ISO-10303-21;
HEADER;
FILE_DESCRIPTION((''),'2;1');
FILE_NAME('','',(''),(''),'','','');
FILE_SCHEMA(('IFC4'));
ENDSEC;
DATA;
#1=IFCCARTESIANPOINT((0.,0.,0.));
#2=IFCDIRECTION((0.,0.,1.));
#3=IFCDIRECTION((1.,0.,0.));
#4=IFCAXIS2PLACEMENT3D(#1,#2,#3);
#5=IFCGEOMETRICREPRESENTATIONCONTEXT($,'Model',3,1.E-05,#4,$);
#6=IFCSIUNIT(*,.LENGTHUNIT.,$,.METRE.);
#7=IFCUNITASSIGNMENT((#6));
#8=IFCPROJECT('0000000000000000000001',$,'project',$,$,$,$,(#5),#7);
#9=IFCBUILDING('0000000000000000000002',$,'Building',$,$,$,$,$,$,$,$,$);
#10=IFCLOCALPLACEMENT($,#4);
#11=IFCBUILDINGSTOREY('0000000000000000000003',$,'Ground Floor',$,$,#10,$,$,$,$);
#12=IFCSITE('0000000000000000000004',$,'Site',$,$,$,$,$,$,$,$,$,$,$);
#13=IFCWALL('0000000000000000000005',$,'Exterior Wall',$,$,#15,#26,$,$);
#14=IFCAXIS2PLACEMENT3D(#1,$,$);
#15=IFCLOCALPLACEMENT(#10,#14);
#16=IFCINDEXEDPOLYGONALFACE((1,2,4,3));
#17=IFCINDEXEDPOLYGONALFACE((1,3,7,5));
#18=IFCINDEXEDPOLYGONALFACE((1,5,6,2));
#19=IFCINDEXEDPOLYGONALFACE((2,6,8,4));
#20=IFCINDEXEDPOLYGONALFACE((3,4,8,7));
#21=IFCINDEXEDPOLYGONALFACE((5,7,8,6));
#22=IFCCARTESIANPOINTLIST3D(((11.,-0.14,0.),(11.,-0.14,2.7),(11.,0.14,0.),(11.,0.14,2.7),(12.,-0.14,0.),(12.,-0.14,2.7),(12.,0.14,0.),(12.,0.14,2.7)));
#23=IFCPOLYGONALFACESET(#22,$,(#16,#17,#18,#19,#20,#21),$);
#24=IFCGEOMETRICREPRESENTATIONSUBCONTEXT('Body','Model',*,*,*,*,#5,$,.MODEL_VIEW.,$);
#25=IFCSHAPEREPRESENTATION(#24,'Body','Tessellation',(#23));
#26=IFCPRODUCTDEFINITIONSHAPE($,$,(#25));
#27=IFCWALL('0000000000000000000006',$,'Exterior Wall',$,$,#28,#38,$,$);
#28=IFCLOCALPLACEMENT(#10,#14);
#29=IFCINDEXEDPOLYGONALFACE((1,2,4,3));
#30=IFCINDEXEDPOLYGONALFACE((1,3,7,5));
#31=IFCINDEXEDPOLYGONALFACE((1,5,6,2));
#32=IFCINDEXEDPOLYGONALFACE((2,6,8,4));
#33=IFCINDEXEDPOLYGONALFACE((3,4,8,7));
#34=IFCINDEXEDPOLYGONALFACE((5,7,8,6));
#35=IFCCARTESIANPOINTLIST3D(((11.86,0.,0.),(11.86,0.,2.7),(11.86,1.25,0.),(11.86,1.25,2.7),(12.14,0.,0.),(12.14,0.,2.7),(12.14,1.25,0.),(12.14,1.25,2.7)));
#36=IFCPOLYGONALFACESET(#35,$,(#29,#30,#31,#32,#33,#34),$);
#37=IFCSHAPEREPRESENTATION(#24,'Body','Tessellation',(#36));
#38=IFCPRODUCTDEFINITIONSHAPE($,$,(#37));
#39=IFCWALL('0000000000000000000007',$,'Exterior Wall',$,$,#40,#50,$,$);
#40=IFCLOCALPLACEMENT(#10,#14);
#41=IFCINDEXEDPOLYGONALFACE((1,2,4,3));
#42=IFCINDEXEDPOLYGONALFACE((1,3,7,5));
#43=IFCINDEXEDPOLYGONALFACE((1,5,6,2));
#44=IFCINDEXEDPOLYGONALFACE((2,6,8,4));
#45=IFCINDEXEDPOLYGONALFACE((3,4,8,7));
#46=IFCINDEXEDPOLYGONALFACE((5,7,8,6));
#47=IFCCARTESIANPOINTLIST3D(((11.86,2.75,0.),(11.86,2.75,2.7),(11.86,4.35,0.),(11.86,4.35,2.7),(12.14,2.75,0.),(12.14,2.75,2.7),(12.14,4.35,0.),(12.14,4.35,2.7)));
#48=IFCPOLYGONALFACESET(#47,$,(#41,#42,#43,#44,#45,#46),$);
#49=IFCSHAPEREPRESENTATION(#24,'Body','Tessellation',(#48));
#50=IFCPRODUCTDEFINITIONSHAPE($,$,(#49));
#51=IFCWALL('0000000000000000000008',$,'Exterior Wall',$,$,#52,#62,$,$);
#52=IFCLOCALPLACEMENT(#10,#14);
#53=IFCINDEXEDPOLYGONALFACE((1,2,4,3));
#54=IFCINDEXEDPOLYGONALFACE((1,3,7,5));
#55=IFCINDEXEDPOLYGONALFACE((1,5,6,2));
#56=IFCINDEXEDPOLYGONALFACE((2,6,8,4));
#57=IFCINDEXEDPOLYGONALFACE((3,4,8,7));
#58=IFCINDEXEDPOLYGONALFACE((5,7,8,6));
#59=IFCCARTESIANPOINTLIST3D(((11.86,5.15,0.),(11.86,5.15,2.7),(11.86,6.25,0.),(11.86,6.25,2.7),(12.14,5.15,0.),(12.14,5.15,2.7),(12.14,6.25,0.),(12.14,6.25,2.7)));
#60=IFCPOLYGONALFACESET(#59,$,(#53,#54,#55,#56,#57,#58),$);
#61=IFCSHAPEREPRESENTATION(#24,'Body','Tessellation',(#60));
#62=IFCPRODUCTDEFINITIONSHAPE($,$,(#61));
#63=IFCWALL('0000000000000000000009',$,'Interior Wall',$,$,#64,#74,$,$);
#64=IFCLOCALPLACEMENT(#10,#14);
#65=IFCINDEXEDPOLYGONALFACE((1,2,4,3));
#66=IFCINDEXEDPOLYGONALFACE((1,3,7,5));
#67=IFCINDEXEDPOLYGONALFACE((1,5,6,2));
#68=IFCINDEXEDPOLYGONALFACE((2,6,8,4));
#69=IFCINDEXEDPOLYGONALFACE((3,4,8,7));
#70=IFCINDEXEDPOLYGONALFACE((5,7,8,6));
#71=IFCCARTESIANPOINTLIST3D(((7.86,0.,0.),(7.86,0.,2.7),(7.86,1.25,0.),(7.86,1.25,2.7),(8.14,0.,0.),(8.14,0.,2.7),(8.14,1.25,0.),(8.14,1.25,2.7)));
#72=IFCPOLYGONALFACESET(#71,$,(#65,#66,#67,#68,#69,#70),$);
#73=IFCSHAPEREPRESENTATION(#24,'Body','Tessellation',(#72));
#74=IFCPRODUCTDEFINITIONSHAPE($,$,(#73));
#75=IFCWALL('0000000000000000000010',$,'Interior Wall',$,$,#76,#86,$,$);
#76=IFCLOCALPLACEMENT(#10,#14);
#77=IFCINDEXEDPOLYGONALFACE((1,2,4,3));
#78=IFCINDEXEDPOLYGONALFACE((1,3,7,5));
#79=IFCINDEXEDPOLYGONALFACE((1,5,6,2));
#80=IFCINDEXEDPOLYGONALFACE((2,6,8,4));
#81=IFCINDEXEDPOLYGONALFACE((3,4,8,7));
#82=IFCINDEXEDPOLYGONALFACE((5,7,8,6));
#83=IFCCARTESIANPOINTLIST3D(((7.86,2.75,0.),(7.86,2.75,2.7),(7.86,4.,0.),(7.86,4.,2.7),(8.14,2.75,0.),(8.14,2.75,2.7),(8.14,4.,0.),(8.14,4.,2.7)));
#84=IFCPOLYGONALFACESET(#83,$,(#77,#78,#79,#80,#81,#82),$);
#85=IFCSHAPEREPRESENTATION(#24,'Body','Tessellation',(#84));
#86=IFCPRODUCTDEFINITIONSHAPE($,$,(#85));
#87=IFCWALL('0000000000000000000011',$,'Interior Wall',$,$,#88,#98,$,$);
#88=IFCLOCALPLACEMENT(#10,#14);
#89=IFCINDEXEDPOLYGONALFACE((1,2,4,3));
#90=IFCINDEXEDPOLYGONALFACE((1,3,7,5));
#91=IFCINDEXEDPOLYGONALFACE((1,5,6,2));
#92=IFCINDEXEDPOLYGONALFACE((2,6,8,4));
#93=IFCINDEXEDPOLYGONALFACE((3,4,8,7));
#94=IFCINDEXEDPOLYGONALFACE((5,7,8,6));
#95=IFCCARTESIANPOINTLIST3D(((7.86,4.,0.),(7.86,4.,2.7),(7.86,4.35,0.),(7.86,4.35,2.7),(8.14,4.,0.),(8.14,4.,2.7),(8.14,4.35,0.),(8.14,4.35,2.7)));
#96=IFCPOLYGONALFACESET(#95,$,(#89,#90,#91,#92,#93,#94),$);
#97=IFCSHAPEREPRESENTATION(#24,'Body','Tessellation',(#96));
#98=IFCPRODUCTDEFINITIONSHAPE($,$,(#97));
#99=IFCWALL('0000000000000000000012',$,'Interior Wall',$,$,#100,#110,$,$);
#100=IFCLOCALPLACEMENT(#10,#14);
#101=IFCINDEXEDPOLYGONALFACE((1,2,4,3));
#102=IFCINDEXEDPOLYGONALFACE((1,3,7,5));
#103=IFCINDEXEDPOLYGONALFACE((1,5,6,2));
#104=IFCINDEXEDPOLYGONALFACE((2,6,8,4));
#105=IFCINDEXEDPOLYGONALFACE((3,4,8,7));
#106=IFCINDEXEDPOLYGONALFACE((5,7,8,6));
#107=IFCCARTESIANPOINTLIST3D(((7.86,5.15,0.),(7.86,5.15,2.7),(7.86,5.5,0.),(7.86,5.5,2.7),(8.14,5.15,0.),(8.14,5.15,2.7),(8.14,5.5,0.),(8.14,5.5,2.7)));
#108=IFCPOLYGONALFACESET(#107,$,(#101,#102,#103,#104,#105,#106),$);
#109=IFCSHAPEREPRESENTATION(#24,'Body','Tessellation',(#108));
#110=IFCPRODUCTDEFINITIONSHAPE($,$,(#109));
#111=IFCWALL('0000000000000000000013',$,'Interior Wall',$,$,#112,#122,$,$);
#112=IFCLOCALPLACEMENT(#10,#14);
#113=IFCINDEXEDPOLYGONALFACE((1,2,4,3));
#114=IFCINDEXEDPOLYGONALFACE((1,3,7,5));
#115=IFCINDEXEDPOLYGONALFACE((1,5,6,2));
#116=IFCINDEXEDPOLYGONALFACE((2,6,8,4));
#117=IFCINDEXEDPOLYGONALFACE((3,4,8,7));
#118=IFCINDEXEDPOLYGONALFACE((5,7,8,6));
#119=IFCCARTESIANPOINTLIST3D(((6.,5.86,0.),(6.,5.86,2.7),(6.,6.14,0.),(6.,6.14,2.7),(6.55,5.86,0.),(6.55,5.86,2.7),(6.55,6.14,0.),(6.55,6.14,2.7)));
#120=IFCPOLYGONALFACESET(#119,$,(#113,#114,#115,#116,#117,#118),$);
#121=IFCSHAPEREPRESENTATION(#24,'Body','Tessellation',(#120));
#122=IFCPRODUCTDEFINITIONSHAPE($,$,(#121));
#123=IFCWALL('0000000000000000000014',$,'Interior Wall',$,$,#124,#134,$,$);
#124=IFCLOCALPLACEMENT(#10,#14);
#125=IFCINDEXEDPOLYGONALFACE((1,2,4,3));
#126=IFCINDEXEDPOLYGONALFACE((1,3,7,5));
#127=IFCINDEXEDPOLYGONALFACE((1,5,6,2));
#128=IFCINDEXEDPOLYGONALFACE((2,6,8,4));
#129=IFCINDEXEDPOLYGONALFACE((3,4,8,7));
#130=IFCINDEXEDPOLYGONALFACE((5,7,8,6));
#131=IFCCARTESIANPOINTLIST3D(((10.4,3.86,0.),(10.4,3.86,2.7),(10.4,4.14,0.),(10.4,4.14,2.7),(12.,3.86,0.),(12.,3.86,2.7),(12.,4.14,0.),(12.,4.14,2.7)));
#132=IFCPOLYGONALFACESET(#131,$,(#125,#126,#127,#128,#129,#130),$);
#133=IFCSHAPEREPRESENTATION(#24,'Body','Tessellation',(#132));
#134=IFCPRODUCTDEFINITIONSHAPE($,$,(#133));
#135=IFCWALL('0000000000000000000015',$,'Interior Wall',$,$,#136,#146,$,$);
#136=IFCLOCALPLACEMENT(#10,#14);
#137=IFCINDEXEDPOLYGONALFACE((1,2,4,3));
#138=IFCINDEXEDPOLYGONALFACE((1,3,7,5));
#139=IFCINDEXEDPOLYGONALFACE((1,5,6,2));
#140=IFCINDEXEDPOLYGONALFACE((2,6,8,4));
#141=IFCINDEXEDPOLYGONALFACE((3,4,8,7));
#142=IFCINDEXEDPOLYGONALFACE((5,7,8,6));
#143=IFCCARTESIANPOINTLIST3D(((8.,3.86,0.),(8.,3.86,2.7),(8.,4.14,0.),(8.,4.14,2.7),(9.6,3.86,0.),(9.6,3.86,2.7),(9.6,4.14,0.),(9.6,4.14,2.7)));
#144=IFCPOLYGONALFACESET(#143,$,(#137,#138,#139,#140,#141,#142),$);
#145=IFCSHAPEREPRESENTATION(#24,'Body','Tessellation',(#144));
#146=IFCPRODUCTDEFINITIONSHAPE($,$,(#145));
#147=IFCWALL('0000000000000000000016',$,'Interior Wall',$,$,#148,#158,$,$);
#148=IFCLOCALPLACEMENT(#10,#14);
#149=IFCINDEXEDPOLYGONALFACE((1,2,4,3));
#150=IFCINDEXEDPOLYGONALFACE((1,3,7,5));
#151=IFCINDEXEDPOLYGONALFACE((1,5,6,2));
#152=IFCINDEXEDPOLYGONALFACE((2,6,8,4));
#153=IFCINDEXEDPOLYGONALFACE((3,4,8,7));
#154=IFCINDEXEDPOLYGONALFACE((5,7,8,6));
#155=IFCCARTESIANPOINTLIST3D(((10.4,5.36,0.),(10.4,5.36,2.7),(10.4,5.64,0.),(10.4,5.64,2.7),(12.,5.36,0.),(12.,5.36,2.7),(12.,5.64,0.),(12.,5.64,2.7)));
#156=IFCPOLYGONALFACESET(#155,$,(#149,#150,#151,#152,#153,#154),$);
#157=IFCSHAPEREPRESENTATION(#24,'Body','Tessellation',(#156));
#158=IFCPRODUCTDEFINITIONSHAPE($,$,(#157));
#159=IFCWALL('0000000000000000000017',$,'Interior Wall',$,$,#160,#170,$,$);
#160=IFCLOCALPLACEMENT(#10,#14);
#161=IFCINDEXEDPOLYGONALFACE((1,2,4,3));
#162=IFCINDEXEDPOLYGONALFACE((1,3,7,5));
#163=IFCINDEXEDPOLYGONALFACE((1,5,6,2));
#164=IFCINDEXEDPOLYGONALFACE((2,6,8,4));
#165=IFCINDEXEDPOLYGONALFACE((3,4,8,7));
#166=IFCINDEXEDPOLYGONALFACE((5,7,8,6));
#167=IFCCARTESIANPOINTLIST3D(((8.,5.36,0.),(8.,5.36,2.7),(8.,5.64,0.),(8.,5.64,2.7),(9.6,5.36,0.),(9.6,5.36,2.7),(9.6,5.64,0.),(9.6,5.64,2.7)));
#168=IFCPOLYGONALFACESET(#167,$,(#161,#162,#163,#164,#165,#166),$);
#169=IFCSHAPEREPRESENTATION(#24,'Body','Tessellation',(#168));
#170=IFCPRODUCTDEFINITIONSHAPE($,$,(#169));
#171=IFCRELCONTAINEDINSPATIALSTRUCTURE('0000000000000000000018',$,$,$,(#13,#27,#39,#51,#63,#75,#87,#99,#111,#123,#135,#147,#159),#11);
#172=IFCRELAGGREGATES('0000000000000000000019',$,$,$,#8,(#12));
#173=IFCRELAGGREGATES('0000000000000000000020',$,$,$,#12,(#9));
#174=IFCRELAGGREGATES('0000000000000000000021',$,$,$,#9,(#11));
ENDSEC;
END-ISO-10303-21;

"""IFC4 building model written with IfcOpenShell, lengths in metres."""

from ifc_helpers import new_model, si_unit, frame, origin_with_axes, place, context, subcontext, project, spatial, indexed_curve, outline, extrude, element, save


model = new_model("IFC4")

# Units and contexts
model_context = context("Model", 3, precision=1e-05, world=origin_with_axes())
body_context = subcontext(model_context, "Body", "Model", "MODEL_VIEW")
ifc_project = project(units=[si_unit("LENGTHUNIT", "METRE")], contexts=[model_context])

# Site, building, storey
site = spatial("IfcSite", under=ifc_project, Name="Site")
building = spatial("IfcBuilding", under=site, Name="Building")
storey_placement = place(None, origin_with_axes())
storey = spatial("IfcBuildingStorey", under=building, at=storey_placement, Name="Ground Floor")

# Walls
wall_1_placement = place(storey_placement, frame((11.0, 0.0, 0.0), z_axis=(0.0, 0.0, 1.0), x_axis=(1.0, 0.0, 0.0)))
element("IfcWall", 1, at=wall_1_placement, inside=storey, Name="Exterior Wall", context=body_context, shape_type="SweptSolid", body=[
    extrude(outline(indexed_curve([(0.0, 0.0), (0.0, 0.28), (1.0, 0.28), (1.0, 0.0), (0.0, 0.0)], self_intersect=False)), frame((0.0, -0.14, 0.0), z_axis=(0.0, 0.0, 1.0), x_axis=(1.0, 0.0, 0.0)), (0.0, 0.0, 1.0), 2.7),
])
wall_2_placement = place(storey_placement, frame((12.0, 0.0, 0.0), z_axis=(0.0, 0.0, 1.0), x_axis=(0.0, 1.0, 0.0)))
element("IfcWall", 2, at=wall_2_placement, inside=storey, Name="Exterior Wall", context=body_context, shape_type="SweptSolid", body=[
    extrude(outline(indexed_curve([(0.0, 0.0), (0.0, 0.28), (1.25, 0.28), (1.25, 0.0), (0.0, 0.0)], self_intersect=False)), frame((0.0, -0.14, 0.0), z_axis=(0.0, 0.0, 1.0), x_axis=(1.0, 0.0, 0.0)), (0.0, 0.0, 1.0), 2.7),
])
wall_3_placement = place(storey_placement, frame((12.0, 2.75, 0.0), z_axis=(0.0, 0.0, 1.0), x_axis=(0.0, 1.0, 0.0)))
element("IfcWall", 3, at=wall_3_placement, inside=storey, Name="Exterior Wall", context=body_context, shape_type="SweptSolid", body=[
    extrude(outline(indexed_curve([(0.0, 0.0), (0.0, 0.28), (1.6, 0.28), (1.6, 0.0), (0.0, 0.0)], self_intersect=False)), frame((0.0, -0.14, 0.0), z_axis=(0.0, 0.0, 1.0), x_axis=(1.0, 0.0, 0.0)), (0.0, 0.0, 1.0), 2.7),
])
wall_4_placement = place(storey_placement, frame((12.0, 5.15, 0.0), z_axis=(0.0, 0.0, 1.0), x_axis=(0.0, 1.0, 0.0)))
element("IfcWall", 4, at=wall_4_placement, inside=storey, Name="Exterior Wall", context=body_context, shape_type="SweptSolid", body=[
    extrude(outline(indexed_curve([(0.0, 0.0), (0.0, 0.28), (1.1, 0.28), (1.1, 0.0), (0.0, 0.0)], self_intersect=False)), frame((0.0, -0.14, 0.0), z_axis=(0.0, 0.0, 1.0), x_axis=(1.0, 0.0, 0.0)), (0.0, 0.0, 1.0), 2.7),
])
for number, where, z_axis, x_axis, name in (
    (5, (8.0, 0.0, 0.0), (0.0, 0.0, 1.0), (0.0, 1.0, 0.0), "Interior Wall"),
    (6, (8.0, 2.75, 0.0), (0.0, 0.0, 1.0), (0.0, 1.0, 0.0), "Interior Wall"),
):
    element("IfcWall", number, at=place(storey_placement, frame(where, z_axis=z_axis, x_axis=x_axis)), inside=storey, Name=name, context=body_context, shape_type="SweptSolid", body=[
        extrude(outline(indexed_curve([(0.0, 0.0), (0.0, 0.28), (1.25, 0.28), (1.25, 0.0), (0.0, 0.0)], self_intersect=False)), frame((0.0, -0.14, 0.0), z_axis=(0.0, 0.0, 1.0), x_axis=(1.0, 0.0, 0.0)), (0.0, 0.0, 1.0), 2.7),
    ])
for number, where, z_axis, x_axis, name in (
    (7, (8.0, 4.0, 0.0), (0.0, 0.0, 1.0), (0.0, 1.0, 0.0), "Interior Wall"),
    (8, (8.0, 5.15, 0.0), (0.0, 0.0, 1.0), (0.0, 1.0, 0.0), "Interior Wall"),
):
    element("IfcWall", number, at=place(storey_placement, frame(where, z_axis=z_axis, x_axis=x_axis)), inside=storey, Name=name, context=body_context, shape_type="SweptSolid", body=[
        extrude(outline(indexed_curve([(0.0, 0.0), (0.0, 0.28), (0.35, 0.28), (0.35, 0.0), (0.0, 0.0)], self_intersect=False)), frame((0.0, -0.14, 0.0), z_axis=(0.0, 0.0, 1.0), x_axis=(1.0, 0.0, 0.0)), (0.0, 0.0, 1.0), 2.7),
    ])
wall_5_placement = place(storey_placement, frame((6.55, 6.0, 0.0), z_axis=(0.0, 0.0, 1.0), x_axis=(-1.0, 0.0, 0.0)))
element("IfcWall", 9, at=wall_5_placement, inside=storey, Name="Interior Wall", context=body_context, shape_type="SweptSolid", body=[
    extrude(outline(indexed_curve([(0.0, 0.0), (0.0, 0.28), (0.55, 0.28), (0.55, 0.0), (0.0, 0.0)], self_intersect=False)), frame((0.0, -0.14, 0.0), z_axis=(0.0, 0.0, 1.0), x_axis=(1.0, 0.0, 0.0)), (0.0, 0.0, 1.0), 2.7),
])
for number, where, z_axis, x_axis, name in (
    (10, (12.0, 4.0, 0.0), (0.0, 0.0, 1.0), (-1.0, 0.0, 0.0), "Interior Wall"),
    (11, (9.6, 4.0, 0.0), (0.0, 0.0, 1.0), (-1.0, 0.0, 0.0), "Interior Wall"),
    (12, (12.0, 5.5, 0.0), (0.0, 0.0, 1.0), (-1.0, 0.0, 0.0), "Interior Wall"),
    (13, (9.6, 5.5, 0.0), (0.0, 0.0, 1.0), (-1.0, 0.0, 0.0), "Interior Wall"),
):
    element("IfcWall", number, at=place(storey_placement, frame(where, z_axis=z_axis, x_axis=x_axis)), inside=storey, Name=name, context=body_context, shape_type="SweptSolid", body=[
        extrude(outline(indexed_curve([(0.0, 0.0), (0.0, 0.28), (1.6, 0.28), (1.6, 0.0), (0.0, 0.0)], self_intersect=False)), frame((0.0, -0.14, 0.0), z_axis=(0.0, 0.0, 1.0), x_axis=(1.0, 0.0, 0.0)), (0.0, 0.0, 1.0), 2.7),
    ])

save(model, "model.ifc")
